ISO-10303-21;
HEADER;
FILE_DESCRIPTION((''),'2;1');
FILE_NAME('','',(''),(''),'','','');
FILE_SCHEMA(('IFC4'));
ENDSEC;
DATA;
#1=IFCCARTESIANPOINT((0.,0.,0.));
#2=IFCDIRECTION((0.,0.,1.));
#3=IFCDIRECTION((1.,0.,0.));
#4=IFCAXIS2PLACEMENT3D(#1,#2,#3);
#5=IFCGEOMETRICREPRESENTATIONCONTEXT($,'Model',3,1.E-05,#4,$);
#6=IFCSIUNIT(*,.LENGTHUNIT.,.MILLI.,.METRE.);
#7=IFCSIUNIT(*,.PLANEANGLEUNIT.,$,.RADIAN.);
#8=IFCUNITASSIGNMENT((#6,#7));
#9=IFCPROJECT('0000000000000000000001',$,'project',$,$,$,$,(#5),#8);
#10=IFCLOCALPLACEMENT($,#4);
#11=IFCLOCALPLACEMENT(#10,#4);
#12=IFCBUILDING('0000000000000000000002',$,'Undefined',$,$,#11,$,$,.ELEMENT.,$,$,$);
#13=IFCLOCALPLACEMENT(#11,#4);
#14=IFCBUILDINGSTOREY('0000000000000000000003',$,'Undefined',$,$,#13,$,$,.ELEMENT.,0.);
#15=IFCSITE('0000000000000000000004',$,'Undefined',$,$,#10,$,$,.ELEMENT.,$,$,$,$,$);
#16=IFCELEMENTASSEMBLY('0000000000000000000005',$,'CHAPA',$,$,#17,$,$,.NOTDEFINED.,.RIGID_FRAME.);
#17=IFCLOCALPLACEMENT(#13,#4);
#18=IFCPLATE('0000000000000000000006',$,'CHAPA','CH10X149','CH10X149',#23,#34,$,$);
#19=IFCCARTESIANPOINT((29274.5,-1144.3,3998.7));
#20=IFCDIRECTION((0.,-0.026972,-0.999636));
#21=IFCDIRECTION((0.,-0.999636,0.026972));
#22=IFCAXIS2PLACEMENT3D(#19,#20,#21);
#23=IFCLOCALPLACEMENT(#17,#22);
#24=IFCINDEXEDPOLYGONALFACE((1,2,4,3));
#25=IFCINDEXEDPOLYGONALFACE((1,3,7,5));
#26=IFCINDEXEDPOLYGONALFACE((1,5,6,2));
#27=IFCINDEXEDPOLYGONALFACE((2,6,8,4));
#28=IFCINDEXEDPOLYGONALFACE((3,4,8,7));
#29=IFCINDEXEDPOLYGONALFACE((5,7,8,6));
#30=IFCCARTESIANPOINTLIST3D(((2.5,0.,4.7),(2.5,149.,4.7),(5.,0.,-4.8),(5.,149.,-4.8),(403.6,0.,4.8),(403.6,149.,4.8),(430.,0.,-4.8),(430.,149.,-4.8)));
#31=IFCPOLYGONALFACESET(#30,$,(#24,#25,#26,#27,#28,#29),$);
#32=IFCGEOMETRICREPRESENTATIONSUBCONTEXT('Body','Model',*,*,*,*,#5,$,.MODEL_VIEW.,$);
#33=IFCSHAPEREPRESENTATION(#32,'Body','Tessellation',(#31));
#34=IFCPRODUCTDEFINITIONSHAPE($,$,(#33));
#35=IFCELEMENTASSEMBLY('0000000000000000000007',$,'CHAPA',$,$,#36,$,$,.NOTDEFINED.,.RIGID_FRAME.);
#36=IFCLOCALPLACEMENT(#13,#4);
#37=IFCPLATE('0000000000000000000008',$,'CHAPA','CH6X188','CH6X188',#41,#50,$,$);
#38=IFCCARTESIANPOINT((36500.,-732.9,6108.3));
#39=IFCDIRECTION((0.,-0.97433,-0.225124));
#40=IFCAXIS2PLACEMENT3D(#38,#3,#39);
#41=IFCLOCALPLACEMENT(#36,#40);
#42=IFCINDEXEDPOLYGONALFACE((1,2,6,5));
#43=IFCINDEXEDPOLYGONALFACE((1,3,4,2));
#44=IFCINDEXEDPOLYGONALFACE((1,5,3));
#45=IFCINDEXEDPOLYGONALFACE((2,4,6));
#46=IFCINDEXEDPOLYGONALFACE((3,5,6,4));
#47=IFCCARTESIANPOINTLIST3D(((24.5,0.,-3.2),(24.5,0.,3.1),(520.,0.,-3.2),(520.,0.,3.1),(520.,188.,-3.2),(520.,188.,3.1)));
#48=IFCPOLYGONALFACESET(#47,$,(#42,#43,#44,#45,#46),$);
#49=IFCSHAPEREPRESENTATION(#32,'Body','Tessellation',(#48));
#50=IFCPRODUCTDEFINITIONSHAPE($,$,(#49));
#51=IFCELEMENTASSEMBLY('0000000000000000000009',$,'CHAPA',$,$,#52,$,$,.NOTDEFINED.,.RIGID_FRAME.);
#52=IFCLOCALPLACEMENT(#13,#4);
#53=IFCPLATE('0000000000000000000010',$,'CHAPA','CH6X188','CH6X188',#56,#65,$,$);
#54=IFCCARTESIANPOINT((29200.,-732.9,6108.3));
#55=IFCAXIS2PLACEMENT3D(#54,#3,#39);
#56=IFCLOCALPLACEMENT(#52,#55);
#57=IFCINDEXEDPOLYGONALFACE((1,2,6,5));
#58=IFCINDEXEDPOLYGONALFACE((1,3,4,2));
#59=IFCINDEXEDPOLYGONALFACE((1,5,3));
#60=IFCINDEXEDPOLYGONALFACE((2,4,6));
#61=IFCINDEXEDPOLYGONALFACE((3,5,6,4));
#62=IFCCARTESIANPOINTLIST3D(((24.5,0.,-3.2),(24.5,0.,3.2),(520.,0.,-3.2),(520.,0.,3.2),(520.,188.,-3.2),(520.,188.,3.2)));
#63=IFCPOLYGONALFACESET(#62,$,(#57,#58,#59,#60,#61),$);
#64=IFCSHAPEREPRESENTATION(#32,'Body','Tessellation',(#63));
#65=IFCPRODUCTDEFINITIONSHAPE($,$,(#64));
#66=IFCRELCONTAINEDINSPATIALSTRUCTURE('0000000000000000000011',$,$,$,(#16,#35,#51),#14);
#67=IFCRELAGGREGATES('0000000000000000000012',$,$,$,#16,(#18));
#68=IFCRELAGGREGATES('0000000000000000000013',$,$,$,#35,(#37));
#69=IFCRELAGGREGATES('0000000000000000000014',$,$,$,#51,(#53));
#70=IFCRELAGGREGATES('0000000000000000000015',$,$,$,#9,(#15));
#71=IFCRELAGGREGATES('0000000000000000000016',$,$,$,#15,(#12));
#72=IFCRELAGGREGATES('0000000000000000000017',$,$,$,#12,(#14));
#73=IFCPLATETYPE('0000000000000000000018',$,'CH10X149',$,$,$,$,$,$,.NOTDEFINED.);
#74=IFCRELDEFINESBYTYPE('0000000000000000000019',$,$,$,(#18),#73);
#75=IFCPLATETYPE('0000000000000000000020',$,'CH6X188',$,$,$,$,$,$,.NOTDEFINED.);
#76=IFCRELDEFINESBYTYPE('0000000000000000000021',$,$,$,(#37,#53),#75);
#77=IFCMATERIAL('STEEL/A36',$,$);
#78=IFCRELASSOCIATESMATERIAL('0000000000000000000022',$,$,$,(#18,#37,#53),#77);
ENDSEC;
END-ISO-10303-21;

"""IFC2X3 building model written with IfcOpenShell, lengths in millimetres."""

from ifc_helpers import new_model, si_unit, frame, origin_with_axes, place, context, subcontext, project, spatial, polyline, outline, extrude, clip, halfspace, material, type_object, element, aggregate, save


model = new_model("IFC2X3")

# Units and contexts
model_context = context("Model", 3, precision=1e-05, world=origin_with_axes())
body_context = subcontext(model_context, "Body", "Model", "MODEL_VIEW")
ifc_project = project(units=[si_unit("LENGTHUNIT", "METRE", prefix="MILLI"), si_unit("PLANEANGLEUNIT", "RADIAN")], contexts=[model_context])

# Site, building, storey
site_placement = place(None, origin_with_axes())
site = spatial("IfcSite", under=ifc_project, at=site_placement, Name="Undefined", CompositionType="ELEMENT")
building_placement = place(site_placement, origin_with_axes())
building = spatial("IfcBuilding", under=site, at=building_placement, Name="Undefined", CompositionType="ELEMENT")
storey_placement = place(building_placement, origin_with_axes())
storey = spatial("IfcBuildingStorey", under=building, at=storey_placement, Name="Undefined", CompositionType="ELEMENT", Elevation=0.0)

# Shared definitions
ifc_material_1 = material(Name="STEEL/A36")

# Element assemblies, plates
plate_type_1 = type_object("IfcPlateType", Name="CH10X149", PredefinedType="NOTDEFINED")
assembly_1_placement = place(storey_placement, origin_with_axes())
assembly_1 = element("IfcElementAssembly", 1, at=assembly_1_placement, inside=storey, Name="CHAPA", AssemblyPlace="NOTDEFINED", PredefinedType="RIGID_FRAME")
plate_1_placement = place(assembly_1_placement, frame((29274.5, -1144.3, 3998.7), z_axis=(0.0, -0.026972, -0.999636), x_axis=(0.0, -0.999636, 0.026972)))
plate_1 = element("IfcPlate", 2, at=plate_1_placement, type_object=plate_type_1, material=ifc_material_1, Name="CHAPA", Description="CH10X149", ObjectType="CH10X149", context=body_context, shape_type="Clipping", body=[
    clip(clip(extrude(outline(polyline([(0.0, 0.0), (430.0, 0.0), (430.0, 149.0), (0.0, 149.0), (0.0, 0.0)])), frame((0.0, 0.0, -4.8), z_axis=(0.0, 0.0, 1.0), x_axis=(1.0, 0.0, 0.0)), (0.0, 0.0, 1.0), 9.5), halfspace(frame((403.6, -500.0, 4.7), z_axis=(0.33881, 0.0, 0.940855), x_axis=(0.0, 1.0, 0.0)), False)), halfspace(frame((5.0, -500.0, -4.8), z_axis=(-0.965989, 0.0, -0.258583), x_axis=(0.0, 1.0, 0.0)), False)),
])
aggregate(assembly_1, [plate_1])
assembly_2_placement = place(storey_placement, origin_with_axes())
assembly_2 = element("IfcElementAssembly", 3, at=assembly_2_placement, inside=storey, Name="CHAPA", AssemblyPlace="NOTDEFINED", PredefinedType="RIGID_FRAME")
plate_type_2 = type_object("IfcPlateType", Name="CH6X188", PredefinedType="NOTDEFINED")
plate_2_placement = place(assembly_2_placement, frame((36500.0, -732.9, 6108.3), z_axis=(1.0, 0.0, 0.0), x_axis=(0.0, -0.97433, -0.225124)))
plate_2 = element("IfcPlate", 4, at=plate_2_placement, type_object=plate_type_2, material=ifc_material_1, Name="CHAPA", Description="CH6X188", ObjectType="CH6X188", context=body_context, shape_type="Clipping", body=[
    clip(extrude(outline(polyline([(0.0, 0.0), (520.0, 0.0), (520.0, 191.6), (0.0, 0.0)])), frame((0.0, 0.0, -3.1), z_axis=(0.0, 0.0, 1.0), x_axis=(1.0, 0.0, 0.0)), (0.0, 0.0, 1.0), 6.3), halfspace(frame((1342.2, 500.0, 3.2), z_axis=(-0.354778, 0.934951, 0.0), x_axis=(-0.934951, -0.354778, 0.0)), False)),
])
aggregate(assembly_2, [plate_2])
assembly_3_placement = place(storey_placement, origin_with_axes())
assembly_3 = element("IfcElementAssembly", 5, at=assembly_3_placement, inside=storey, Name="CHAPA", AssemblyPlace="NOTDEFINED", PredefinedType="RIGID_FRAME")
plate_3_placement = place(assembly_3_placement, frame((29200.0, -732.9, 6108.3), z_axis=(1.0, 0.0, 0.0), x_axis=(0.0, -0.97433, -0.225124)))
plate_3 = element("IfcPlate", 6, at=plate_3_placement, type_object=plate_type_2, material=ifc_material_1, Name="CHAPA", Description="CH6X188", ObjectType="CH6X188", context=body_context, shape_type="Clipping", body=[
    clip(extrude(outline(polyline([(0.0, 0.0), (520.0, 0.0), (520.0, 191.6), (0.0, 0.0)])), frame((0.0, 0.0, -3.1), z_axis=(0.0, 0.0, 1.0), x_axis=(1.0, 0.0, 0.0)), (0.0, 0.0, 1.0), 6.3), halfspace(frame((1342.2, 500.0, 3.2), z_axis=(-0.354778, 0.934951, 0.0), x_axis=(-0.934951, -0.354778, 0.0)), False)),
])
aggregate(assembly_3, [plate_3])

save(model, "model.ifc")
